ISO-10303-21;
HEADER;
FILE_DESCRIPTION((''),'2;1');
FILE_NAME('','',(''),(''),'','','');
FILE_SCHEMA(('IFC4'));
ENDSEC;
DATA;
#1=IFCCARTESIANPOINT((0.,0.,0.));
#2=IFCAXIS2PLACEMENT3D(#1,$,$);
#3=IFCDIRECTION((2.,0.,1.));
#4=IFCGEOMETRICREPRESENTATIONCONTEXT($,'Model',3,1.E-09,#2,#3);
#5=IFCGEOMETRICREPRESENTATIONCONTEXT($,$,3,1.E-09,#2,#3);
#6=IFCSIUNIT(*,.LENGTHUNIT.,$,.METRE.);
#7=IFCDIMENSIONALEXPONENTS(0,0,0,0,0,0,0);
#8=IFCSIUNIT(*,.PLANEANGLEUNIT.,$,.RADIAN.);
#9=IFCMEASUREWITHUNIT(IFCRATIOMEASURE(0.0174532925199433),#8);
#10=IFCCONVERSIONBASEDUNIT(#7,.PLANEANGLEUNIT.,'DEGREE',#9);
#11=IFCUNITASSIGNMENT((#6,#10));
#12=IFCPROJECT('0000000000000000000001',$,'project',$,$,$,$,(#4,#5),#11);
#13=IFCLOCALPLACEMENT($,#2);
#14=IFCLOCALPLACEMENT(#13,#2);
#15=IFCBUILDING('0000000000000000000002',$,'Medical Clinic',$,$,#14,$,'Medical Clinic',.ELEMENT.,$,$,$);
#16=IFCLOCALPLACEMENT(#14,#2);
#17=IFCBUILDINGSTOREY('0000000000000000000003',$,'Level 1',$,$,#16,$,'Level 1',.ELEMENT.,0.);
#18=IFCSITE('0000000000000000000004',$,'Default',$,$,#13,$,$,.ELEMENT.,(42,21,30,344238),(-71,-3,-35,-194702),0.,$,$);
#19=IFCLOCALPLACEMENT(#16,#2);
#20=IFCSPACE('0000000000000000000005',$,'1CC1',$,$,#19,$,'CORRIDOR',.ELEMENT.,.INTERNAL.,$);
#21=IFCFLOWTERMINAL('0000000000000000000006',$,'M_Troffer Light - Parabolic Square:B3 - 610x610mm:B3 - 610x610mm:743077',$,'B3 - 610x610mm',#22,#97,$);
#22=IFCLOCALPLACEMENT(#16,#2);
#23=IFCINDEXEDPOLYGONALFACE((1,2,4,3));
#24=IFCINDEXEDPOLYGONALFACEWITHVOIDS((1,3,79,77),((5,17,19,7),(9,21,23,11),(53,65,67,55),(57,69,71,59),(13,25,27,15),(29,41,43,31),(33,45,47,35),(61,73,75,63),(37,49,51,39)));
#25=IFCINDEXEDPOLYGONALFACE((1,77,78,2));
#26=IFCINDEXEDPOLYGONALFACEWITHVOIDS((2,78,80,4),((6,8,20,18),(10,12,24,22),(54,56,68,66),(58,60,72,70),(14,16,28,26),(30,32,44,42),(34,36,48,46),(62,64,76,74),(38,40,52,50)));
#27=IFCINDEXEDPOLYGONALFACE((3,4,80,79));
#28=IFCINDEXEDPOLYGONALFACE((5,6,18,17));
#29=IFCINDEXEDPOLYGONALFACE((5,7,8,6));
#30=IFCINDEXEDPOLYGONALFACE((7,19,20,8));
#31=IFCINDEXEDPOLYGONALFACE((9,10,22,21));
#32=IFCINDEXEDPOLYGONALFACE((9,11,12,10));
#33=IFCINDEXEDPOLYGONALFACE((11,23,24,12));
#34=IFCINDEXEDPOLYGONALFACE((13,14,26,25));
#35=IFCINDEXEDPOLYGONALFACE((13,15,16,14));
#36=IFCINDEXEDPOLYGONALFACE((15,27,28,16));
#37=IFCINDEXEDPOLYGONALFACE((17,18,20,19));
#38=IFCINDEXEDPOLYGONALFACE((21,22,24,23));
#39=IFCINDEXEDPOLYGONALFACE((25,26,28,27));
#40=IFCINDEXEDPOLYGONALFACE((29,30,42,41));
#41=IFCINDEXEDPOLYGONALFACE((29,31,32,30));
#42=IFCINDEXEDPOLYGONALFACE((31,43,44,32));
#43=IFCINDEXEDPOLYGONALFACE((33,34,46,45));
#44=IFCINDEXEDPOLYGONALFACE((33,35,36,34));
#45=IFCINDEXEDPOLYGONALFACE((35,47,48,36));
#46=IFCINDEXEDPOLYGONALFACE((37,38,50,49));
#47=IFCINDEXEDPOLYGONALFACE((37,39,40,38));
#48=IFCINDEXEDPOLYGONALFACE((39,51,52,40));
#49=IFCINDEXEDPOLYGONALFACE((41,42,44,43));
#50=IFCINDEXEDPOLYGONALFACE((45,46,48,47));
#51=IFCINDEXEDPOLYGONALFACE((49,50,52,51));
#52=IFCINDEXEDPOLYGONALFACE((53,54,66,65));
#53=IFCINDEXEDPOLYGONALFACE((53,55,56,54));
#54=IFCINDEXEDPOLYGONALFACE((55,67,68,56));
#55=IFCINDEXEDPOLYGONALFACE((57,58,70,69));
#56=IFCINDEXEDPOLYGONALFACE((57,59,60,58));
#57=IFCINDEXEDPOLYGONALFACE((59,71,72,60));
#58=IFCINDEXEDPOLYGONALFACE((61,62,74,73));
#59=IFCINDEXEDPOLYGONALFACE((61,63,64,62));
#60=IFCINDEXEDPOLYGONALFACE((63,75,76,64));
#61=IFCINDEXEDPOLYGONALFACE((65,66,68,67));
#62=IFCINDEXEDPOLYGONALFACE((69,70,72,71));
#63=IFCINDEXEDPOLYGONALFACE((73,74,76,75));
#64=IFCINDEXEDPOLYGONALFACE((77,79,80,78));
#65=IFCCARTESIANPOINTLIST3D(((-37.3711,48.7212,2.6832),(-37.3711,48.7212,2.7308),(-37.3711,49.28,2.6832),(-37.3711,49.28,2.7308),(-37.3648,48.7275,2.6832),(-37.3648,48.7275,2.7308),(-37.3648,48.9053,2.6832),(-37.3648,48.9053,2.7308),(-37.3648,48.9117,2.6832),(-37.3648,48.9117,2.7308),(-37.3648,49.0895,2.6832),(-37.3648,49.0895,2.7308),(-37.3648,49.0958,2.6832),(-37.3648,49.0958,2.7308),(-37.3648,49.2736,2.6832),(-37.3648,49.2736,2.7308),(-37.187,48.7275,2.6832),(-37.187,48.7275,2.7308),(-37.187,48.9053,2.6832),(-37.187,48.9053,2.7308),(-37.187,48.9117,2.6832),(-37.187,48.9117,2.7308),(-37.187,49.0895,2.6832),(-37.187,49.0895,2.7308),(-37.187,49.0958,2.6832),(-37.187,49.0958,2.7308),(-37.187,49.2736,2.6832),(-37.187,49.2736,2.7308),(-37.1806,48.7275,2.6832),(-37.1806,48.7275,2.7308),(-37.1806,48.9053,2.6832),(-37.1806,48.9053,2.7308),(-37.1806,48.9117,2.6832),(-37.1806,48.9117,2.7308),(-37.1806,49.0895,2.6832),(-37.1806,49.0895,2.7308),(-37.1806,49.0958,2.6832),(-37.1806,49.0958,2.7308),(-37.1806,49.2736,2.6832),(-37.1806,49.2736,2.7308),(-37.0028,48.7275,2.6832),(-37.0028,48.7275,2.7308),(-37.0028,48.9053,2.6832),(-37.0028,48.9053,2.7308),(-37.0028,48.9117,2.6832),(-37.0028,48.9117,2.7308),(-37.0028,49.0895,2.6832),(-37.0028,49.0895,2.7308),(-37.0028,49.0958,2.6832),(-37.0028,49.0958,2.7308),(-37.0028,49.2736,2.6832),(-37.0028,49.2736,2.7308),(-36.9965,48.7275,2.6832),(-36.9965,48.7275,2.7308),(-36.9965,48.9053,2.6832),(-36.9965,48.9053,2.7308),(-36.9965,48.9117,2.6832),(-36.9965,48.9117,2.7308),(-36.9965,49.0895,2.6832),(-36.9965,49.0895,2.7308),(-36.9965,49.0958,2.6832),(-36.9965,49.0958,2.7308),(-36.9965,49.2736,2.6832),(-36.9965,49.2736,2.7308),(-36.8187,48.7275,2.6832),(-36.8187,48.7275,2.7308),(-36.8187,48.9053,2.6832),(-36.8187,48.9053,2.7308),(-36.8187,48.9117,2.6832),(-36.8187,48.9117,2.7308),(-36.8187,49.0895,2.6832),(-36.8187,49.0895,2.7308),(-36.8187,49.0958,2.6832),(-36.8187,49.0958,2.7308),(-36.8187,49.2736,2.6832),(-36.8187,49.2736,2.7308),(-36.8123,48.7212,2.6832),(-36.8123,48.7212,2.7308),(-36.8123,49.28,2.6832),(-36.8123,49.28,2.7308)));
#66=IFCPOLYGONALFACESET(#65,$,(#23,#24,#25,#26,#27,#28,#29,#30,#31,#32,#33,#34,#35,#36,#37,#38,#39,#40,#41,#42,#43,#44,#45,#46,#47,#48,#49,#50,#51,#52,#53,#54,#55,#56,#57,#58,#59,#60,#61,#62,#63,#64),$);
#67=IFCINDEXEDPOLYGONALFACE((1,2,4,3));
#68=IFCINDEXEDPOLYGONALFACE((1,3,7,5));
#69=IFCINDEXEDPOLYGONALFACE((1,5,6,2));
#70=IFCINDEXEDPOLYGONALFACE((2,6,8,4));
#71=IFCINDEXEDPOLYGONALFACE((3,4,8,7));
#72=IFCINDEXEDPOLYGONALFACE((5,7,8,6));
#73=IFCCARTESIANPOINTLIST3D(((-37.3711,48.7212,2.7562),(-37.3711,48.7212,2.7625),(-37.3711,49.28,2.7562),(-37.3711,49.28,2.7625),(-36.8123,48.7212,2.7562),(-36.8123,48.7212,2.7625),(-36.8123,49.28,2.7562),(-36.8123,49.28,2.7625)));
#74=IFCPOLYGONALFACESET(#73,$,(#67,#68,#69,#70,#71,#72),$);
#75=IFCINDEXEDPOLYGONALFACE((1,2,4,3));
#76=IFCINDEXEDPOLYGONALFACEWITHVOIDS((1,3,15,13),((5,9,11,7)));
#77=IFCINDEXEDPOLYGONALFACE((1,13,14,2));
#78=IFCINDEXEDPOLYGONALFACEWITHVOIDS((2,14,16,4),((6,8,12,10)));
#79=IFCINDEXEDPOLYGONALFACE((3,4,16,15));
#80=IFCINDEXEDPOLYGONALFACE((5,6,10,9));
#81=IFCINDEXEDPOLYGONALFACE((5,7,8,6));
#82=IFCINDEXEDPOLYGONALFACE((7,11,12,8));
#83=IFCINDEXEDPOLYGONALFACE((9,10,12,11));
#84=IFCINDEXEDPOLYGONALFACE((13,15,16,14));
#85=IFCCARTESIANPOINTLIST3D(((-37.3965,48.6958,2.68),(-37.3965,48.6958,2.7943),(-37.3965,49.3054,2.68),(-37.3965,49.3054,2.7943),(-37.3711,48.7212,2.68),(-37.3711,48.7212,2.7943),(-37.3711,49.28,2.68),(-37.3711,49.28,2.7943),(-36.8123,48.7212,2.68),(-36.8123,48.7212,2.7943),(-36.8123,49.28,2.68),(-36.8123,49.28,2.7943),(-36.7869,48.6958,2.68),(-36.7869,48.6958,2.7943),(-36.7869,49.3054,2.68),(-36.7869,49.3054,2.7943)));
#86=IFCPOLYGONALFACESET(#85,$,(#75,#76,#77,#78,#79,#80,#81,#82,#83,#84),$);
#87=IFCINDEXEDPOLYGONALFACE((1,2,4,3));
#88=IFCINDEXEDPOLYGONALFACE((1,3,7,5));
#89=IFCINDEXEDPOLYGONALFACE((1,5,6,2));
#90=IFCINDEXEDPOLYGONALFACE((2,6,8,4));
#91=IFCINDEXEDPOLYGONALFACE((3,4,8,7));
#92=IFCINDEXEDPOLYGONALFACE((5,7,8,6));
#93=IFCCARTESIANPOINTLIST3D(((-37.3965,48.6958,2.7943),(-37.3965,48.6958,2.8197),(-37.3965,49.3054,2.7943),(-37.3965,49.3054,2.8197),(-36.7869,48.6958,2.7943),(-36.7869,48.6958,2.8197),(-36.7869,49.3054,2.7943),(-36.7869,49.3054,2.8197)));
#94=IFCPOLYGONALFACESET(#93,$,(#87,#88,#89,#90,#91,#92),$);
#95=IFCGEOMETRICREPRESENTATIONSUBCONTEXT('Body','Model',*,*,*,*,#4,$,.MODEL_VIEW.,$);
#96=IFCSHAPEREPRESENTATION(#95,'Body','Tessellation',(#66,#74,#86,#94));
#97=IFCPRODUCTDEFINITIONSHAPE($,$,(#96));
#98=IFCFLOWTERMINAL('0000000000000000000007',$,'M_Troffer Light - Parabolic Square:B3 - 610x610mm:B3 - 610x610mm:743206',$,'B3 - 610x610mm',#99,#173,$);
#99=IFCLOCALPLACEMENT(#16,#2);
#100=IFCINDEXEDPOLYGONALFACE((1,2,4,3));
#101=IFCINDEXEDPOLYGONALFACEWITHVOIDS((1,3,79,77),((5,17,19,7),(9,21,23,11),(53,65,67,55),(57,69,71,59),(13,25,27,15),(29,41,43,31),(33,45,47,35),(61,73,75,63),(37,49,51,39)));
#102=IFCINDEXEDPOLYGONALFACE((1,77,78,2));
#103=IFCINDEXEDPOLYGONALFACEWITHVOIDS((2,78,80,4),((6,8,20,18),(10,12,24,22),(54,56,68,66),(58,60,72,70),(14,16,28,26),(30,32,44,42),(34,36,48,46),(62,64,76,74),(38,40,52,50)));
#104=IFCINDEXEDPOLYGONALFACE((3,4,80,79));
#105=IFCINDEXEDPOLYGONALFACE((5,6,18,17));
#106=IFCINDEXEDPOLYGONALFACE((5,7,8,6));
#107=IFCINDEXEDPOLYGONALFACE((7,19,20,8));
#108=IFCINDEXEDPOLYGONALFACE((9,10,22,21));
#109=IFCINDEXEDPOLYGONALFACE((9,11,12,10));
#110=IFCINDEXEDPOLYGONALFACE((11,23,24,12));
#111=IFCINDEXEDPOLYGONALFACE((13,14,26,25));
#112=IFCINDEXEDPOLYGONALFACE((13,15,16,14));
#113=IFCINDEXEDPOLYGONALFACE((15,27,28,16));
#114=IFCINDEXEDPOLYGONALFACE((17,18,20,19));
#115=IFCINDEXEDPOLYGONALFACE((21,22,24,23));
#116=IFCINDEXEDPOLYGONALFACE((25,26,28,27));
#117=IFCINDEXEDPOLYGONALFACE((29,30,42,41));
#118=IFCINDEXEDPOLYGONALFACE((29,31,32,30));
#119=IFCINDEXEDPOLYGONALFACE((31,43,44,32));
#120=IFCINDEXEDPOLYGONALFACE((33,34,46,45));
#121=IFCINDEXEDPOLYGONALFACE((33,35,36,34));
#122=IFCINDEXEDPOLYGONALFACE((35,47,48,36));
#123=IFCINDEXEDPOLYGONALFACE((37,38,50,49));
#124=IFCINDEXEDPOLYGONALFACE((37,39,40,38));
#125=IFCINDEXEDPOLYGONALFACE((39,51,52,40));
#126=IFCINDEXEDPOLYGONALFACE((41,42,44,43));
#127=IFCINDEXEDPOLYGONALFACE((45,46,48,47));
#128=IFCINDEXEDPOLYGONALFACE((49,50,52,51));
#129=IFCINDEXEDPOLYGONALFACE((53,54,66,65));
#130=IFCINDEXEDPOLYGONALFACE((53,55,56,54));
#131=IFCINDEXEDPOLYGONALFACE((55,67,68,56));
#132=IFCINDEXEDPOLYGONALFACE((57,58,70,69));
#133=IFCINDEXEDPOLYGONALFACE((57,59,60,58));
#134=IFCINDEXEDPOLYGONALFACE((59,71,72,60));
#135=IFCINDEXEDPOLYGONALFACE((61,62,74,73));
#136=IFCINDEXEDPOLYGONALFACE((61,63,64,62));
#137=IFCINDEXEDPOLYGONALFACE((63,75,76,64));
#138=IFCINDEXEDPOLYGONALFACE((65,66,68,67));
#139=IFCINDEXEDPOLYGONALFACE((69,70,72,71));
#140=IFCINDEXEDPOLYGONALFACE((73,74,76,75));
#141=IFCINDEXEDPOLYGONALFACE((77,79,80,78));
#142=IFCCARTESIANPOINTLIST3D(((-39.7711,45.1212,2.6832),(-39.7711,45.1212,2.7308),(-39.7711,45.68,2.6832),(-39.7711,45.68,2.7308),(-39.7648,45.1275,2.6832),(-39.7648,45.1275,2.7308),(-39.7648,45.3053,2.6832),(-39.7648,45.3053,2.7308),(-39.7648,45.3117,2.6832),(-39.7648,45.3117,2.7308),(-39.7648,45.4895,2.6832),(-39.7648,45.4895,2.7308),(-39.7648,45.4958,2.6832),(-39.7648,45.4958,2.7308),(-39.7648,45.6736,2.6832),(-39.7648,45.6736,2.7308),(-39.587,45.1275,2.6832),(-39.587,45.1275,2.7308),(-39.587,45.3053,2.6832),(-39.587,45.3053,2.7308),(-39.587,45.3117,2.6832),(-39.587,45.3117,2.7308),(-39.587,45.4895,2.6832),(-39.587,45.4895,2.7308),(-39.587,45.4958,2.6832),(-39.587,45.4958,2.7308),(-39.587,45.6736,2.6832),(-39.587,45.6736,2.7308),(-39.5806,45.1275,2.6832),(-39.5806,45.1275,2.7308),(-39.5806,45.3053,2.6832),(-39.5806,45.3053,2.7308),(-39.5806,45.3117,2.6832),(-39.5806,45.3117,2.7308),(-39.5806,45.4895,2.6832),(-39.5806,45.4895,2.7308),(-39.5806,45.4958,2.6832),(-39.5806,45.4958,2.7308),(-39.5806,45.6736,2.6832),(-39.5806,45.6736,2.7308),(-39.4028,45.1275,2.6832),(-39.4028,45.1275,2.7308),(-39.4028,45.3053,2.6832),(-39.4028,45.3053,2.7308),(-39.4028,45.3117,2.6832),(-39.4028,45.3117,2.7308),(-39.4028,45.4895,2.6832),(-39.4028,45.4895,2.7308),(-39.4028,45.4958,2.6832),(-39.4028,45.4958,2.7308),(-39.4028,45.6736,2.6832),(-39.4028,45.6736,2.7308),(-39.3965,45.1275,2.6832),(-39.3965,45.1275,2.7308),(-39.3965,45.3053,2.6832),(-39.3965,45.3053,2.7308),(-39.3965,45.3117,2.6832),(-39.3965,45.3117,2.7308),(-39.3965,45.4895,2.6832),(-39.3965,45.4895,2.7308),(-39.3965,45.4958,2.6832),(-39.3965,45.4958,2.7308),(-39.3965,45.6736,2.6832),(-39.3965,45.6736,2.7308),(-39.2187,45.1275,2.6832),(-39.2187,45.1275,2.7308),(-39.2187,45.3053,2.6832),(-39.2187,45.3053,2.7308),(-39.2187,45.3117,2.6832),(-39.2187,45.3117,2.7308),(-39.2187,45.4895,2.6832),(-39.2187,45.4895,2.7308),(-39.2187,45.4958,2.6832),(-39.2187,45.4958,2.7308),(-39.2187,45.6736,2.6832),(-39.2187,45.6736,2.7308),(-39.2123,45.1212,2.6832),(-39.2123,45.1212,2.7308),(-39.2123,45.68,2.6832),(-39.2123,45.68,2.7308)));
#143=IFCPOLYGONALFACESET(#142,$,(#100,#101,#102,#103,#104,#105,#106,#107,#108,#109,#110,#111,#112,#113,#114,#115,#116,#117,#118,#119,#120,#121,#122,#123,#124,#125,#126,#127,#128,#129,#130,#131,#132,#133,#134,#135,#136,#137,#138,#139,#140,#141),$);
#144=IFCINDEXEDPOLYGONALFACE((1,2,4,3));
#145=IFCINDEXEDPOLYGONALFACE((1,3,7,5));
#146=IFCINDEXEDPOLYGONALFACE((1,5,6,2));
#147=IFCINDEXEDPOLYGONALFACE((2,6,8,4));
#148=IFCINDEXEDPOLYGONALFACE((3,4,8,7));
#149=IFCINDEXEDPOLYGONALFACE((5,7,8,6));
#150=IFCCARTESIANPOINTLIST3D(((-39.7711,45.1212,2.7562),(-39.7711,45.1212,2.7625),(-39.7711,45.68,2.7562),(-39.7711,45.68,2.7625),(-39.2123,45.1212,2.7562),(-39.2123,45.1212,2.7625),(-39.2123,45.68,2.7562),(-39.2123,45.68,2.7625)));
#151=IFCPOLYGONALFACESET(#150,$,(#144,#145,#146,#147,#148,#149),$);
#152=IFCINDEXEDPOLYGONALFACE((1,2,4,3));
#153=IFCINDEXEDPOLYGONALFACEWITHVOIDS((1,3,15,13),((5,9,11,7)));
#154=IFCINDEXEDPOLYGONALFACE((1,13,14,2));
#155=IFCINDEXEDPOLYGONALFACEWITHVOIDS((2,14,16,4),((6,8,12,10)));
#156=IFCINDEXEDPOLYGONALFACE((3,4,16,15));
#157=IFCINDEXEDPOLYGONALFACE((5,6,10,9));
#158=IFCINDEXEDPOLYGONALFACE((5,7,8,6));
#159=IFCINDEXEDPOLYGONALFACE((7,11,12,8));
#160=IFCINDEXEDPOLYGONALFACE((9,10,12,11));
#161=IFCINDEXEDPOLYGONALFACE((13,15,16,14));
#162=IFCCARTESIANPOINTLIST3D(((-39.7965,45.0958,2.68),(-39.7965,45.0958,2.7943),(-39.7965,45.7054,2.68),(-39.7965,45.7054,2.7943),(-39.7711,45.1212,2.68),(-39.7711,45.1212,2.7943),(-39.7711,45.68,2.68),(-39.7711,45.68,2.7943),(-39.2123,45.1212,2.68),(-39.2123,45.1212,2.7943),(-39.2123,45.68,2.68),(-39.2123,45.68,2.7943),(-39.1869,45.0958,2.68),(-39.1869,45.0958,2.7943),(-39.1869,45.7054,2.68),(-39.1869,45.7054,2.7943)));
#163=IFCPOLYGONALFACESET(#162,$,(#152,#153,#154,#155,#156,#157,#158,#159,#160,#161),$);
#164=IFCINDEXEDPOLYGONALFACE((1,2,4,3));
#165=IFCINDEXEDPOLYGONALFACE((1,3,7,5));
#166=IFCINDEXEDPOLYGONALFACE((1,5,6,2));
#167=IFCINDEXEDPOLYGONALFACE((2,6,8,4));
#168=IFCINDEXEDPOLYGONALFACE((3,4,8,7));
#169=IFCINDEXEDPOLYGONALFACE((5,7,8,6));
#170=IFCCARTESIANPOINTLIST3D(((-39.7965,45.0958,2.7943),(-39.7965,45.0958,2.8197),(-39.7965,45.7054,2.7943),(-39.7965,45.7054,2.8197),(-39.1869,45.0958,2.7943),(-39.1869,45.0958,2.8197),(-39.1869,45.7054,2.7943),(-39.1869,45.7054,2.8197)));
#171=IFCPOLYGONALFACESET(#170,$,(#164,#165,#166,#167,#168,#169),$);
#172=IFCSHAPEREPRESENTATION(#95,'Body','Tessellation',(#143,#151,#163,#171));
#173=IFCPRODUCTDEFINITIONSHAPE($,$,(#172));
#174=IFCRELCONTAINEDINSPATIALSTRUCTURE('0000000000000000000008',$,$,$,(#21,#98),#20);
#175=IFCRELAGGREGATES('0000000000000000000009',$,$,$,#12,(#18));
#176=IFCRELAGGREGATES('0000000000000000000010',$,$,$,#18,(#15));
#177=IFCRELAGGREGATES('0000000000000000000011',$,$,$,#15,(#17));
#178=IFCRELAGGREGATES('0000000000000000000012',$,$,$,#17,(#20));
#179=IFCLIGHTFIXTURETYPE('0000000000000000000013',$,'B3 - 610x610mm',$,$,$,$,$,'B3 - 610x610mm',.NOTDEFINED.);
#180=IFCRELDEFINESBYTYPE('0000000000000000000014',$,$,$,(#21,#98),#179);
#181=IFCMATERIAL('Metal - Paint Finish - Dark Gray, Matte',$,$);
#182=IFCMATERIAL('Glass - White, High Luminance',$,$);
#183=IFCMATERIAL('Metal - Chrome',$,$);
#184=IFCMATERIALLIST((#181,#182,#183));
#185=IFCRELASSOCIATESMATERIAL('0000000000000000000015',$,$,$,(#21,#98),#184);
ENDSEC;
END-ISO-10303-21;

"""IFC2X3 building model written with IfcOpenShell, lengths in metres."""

from ifc_helpers import new_model, entity, si_unit, converted_unit, direction, frame, origin, origin_2d_with_axis, place, context, subcontext, project, spatial, polyline, rectangle, outline, extrude, source, transform, mapped, material, material_list, type_object, type_shapes, element, save


model = new_model("IFC2X3")

# Units and contexts
model_context = context("Model", 3, precision=1e-09, world=origin(), true_north=direction((2.0, 0.0, 1.0)))
context_of_model = context(None, 3, precision=1e-09, world=origin(), true_north=direction((2.0, 0.0, 1.0)))
body_context = subcontext(model_context, "Body", "Model", "MODEL_VIEW")
ifc_project = project(units=[si_unit("LENGTHUNIT", "METRE"), converted_unit("PLANEANGLEUNIT", "DEGREE", entity("IfcRatioMeasure", 0.0174532925199433), si_unit("PLANEANGLEUNIT", "RADIAN"), dimensions=[0, 0, 0, 0, 0, 0, 0])], contexts=[model_context, context_of_model])

# Site, building, storey
site_placement = place(None, origin())
site = spatial("IfcSite", under=ifc_project, at=site_placement, Name="Default", CompositionType="ELEMENT", RefLatitude=(42, 21, 30, 344238), RefLongitude=(-71, -3, -35, -194702), RefElevation=0.0)
building_placement = place(site_placement, origin())
building = spatial("IfcBuilding", under=site, at=building_placement, Name="Medical Clinic", LongName="Medical Clinic", CompositionType="ELEMENT")
storey_placement = place(building_placement, origin())
storey = spatial("IfcBuildingStorey", under=building, at=storey_placement, Name="Level 1", LongName="Level 1", CompositionType="ELEMENT", Elevation=0.0)

# Shared definitions
space_1_placement = place(storey_placement, origin())
space_1 = spatial("IfcSpace", under=storey, at=space_1_placement, Name="1CC1", LongName="CORRIDOR", CompositionType="ELEMENT", InteriorOrExteriorSpace="INTERNAL")

# Flow terminals
ifc_material_1 = material(Name="Metal - Paint Finish - Dark Gray, Matte")
ifc_material_2 = material(Name="Glass - White, High Luminance")
ifc_material_3 = material(Name="Metal - Chrome")
ifc_material_list_1 = material_list([ifc_material_1, ifc_material_2, ifc_material_3])
light_fixture_type_1 = type_object("IfcLightFixtureType", Name="B3 - 610x610mm", ElementType="B3 - 610x610mm", PredefinedType="NOTDEFINED")
shared_shape_1 = source(origin(), body_context, "Body", "SweptSolid", [
    extrude(outline(polyline([(-0.2794, -0.2794), (0.2794, -0.2794), (0.2794, 0.2794), (-0.2794, 0.2794), (-0.2794, -0.2794)]), holes=[polyline([(-0.0952, 0.0953), (-0.273, 0.0953), (-0.273, 0.2731), (-0.0952, 0.2731), (-0.0952, 0.0953)]), polyline([(0.2731, 0.0953), (0.0953, 0.0953), (0.0953, 0.2731), (0.2731, 0.2731), (0.2731, 0.0953)]), polyline([(-0.0889, 0.2731), (0.0889, 0.2731), (0.0889, 0.0953), (-0.0889, 0.0953), (-0.0889, 0.2731)]), polyline([(0.2731, -0.273), (0.0953, -0.273), (0.0953, -0.0952), (0.2731, -0.0952), (0.2731, -0.273)]), polyline([(0.0889, -0.273), (-0.0889, -0.273), (-0.0889, -0.0952), (0.0889, -0.0952), (0.0889, -0.273)]), polyline([(-0.0952, -0.273), (-0.273, -0.273), (-0.273, -0.0952), (-0.0952, -0.0952), (-0.0952, -0.273)]), polyline([(-0.0952, -0.0889), (-0.273, -0.0889), (-0.273, 0.0889), (-0.0952, 0.0889), (-0.0952, -0.0889)]), polyline([(0.0889, -0.0889), (-0.0889, -0.0889), (-0.0889, 0.0889), (0.0889, 0.0889), (0.0889, -0.0889)]), polyline([(0.2731, -0.0889), (0.0953, -0.0889), (0.0953, 0.0889), (0.2731, 0.0889), (0.2731, -0.0889)])]), frame((0.0, -0.3048, -0.0508), z_axis=(0.0, 0.0, 1.0), x_axis=(-1.0, 0.0, 0.0)), (0.0, 0.0, 1.0), 0.0476),
    extrude(rectangle(XDim=0.5588, YDim=0.5588, at=origin_2d_with_axis()), frame((0.0, -0.3048, -0.0825), z_axis=(0.0, 0.0, 1.0), x_axis=(-1.0, 0.0, 0.0)), (0.0, 0.0, 1.0), 0.0064),
    extrude(outline(polyline([(-0.3048, -0.3048), (0.3048, -0.3048), (0.3048, 0.3048), (-0.3048, 0.3048), (-0.3048, -0.3048)]), holes=[polyline([(0.2794, 0.2794), (0.2794, -0.2794), (-0.2794, -0.2794), (-0.2794, 0.2794), (0.2794, 0.2794)])]), frame((0.0, -0.3048, -0.1143)), (0.0, 0.0, 1.0), 0.1143),
    extrude(rectangle(XDim=0.6096, YDim=0.6096, at=origin_2d_with_axis()), frame((0.0, -0.3048, -0.1397), z_axis=(0.0, 0.0, 1.0), x_axis=(-1.0, 0.0, 0.0)), (0.0, 0.0, 1.0), 0.0254),
])
type_shapes(light_fixture_type_1, [shared_shape_1])
for number, where, z_axis, x_axis, name in (
    (1, (-37.0917, 48.6958, 2.68), (0.0, 0.0, -1.0), (1.0, 0.0, 0.0), "M_Troffer Light - Parabolic Square:B3 - 610x610mm:B3 - 610x610mm:743077"),
    (2, (-39.4917, 45.0958, 2.68), (0.0, 0.0, -1.0), (1.0, 0.0, 0.0), "M_Troffer Light - Parabolic Square:B3 - 610x610mm:B3 - 610x610mm:743206"),
):
    element("IfcFlowTerminal", number, at=place(space_1_placement, frame(where, z_axis=z_axis, x_axis=x_axis)), inside=space_1, type_object=light_fixture_type_1, material=ifc_material_list_1, Name=name, ObjectType="B3 - 610x610mm", context=body_context, shape_type="MappedRepresentation", body=[
        mapped(shared_shape_1, transform((0.0, 0.0, 0.0), scale=1.0)),
    ])

save(model, "model.ifc")
